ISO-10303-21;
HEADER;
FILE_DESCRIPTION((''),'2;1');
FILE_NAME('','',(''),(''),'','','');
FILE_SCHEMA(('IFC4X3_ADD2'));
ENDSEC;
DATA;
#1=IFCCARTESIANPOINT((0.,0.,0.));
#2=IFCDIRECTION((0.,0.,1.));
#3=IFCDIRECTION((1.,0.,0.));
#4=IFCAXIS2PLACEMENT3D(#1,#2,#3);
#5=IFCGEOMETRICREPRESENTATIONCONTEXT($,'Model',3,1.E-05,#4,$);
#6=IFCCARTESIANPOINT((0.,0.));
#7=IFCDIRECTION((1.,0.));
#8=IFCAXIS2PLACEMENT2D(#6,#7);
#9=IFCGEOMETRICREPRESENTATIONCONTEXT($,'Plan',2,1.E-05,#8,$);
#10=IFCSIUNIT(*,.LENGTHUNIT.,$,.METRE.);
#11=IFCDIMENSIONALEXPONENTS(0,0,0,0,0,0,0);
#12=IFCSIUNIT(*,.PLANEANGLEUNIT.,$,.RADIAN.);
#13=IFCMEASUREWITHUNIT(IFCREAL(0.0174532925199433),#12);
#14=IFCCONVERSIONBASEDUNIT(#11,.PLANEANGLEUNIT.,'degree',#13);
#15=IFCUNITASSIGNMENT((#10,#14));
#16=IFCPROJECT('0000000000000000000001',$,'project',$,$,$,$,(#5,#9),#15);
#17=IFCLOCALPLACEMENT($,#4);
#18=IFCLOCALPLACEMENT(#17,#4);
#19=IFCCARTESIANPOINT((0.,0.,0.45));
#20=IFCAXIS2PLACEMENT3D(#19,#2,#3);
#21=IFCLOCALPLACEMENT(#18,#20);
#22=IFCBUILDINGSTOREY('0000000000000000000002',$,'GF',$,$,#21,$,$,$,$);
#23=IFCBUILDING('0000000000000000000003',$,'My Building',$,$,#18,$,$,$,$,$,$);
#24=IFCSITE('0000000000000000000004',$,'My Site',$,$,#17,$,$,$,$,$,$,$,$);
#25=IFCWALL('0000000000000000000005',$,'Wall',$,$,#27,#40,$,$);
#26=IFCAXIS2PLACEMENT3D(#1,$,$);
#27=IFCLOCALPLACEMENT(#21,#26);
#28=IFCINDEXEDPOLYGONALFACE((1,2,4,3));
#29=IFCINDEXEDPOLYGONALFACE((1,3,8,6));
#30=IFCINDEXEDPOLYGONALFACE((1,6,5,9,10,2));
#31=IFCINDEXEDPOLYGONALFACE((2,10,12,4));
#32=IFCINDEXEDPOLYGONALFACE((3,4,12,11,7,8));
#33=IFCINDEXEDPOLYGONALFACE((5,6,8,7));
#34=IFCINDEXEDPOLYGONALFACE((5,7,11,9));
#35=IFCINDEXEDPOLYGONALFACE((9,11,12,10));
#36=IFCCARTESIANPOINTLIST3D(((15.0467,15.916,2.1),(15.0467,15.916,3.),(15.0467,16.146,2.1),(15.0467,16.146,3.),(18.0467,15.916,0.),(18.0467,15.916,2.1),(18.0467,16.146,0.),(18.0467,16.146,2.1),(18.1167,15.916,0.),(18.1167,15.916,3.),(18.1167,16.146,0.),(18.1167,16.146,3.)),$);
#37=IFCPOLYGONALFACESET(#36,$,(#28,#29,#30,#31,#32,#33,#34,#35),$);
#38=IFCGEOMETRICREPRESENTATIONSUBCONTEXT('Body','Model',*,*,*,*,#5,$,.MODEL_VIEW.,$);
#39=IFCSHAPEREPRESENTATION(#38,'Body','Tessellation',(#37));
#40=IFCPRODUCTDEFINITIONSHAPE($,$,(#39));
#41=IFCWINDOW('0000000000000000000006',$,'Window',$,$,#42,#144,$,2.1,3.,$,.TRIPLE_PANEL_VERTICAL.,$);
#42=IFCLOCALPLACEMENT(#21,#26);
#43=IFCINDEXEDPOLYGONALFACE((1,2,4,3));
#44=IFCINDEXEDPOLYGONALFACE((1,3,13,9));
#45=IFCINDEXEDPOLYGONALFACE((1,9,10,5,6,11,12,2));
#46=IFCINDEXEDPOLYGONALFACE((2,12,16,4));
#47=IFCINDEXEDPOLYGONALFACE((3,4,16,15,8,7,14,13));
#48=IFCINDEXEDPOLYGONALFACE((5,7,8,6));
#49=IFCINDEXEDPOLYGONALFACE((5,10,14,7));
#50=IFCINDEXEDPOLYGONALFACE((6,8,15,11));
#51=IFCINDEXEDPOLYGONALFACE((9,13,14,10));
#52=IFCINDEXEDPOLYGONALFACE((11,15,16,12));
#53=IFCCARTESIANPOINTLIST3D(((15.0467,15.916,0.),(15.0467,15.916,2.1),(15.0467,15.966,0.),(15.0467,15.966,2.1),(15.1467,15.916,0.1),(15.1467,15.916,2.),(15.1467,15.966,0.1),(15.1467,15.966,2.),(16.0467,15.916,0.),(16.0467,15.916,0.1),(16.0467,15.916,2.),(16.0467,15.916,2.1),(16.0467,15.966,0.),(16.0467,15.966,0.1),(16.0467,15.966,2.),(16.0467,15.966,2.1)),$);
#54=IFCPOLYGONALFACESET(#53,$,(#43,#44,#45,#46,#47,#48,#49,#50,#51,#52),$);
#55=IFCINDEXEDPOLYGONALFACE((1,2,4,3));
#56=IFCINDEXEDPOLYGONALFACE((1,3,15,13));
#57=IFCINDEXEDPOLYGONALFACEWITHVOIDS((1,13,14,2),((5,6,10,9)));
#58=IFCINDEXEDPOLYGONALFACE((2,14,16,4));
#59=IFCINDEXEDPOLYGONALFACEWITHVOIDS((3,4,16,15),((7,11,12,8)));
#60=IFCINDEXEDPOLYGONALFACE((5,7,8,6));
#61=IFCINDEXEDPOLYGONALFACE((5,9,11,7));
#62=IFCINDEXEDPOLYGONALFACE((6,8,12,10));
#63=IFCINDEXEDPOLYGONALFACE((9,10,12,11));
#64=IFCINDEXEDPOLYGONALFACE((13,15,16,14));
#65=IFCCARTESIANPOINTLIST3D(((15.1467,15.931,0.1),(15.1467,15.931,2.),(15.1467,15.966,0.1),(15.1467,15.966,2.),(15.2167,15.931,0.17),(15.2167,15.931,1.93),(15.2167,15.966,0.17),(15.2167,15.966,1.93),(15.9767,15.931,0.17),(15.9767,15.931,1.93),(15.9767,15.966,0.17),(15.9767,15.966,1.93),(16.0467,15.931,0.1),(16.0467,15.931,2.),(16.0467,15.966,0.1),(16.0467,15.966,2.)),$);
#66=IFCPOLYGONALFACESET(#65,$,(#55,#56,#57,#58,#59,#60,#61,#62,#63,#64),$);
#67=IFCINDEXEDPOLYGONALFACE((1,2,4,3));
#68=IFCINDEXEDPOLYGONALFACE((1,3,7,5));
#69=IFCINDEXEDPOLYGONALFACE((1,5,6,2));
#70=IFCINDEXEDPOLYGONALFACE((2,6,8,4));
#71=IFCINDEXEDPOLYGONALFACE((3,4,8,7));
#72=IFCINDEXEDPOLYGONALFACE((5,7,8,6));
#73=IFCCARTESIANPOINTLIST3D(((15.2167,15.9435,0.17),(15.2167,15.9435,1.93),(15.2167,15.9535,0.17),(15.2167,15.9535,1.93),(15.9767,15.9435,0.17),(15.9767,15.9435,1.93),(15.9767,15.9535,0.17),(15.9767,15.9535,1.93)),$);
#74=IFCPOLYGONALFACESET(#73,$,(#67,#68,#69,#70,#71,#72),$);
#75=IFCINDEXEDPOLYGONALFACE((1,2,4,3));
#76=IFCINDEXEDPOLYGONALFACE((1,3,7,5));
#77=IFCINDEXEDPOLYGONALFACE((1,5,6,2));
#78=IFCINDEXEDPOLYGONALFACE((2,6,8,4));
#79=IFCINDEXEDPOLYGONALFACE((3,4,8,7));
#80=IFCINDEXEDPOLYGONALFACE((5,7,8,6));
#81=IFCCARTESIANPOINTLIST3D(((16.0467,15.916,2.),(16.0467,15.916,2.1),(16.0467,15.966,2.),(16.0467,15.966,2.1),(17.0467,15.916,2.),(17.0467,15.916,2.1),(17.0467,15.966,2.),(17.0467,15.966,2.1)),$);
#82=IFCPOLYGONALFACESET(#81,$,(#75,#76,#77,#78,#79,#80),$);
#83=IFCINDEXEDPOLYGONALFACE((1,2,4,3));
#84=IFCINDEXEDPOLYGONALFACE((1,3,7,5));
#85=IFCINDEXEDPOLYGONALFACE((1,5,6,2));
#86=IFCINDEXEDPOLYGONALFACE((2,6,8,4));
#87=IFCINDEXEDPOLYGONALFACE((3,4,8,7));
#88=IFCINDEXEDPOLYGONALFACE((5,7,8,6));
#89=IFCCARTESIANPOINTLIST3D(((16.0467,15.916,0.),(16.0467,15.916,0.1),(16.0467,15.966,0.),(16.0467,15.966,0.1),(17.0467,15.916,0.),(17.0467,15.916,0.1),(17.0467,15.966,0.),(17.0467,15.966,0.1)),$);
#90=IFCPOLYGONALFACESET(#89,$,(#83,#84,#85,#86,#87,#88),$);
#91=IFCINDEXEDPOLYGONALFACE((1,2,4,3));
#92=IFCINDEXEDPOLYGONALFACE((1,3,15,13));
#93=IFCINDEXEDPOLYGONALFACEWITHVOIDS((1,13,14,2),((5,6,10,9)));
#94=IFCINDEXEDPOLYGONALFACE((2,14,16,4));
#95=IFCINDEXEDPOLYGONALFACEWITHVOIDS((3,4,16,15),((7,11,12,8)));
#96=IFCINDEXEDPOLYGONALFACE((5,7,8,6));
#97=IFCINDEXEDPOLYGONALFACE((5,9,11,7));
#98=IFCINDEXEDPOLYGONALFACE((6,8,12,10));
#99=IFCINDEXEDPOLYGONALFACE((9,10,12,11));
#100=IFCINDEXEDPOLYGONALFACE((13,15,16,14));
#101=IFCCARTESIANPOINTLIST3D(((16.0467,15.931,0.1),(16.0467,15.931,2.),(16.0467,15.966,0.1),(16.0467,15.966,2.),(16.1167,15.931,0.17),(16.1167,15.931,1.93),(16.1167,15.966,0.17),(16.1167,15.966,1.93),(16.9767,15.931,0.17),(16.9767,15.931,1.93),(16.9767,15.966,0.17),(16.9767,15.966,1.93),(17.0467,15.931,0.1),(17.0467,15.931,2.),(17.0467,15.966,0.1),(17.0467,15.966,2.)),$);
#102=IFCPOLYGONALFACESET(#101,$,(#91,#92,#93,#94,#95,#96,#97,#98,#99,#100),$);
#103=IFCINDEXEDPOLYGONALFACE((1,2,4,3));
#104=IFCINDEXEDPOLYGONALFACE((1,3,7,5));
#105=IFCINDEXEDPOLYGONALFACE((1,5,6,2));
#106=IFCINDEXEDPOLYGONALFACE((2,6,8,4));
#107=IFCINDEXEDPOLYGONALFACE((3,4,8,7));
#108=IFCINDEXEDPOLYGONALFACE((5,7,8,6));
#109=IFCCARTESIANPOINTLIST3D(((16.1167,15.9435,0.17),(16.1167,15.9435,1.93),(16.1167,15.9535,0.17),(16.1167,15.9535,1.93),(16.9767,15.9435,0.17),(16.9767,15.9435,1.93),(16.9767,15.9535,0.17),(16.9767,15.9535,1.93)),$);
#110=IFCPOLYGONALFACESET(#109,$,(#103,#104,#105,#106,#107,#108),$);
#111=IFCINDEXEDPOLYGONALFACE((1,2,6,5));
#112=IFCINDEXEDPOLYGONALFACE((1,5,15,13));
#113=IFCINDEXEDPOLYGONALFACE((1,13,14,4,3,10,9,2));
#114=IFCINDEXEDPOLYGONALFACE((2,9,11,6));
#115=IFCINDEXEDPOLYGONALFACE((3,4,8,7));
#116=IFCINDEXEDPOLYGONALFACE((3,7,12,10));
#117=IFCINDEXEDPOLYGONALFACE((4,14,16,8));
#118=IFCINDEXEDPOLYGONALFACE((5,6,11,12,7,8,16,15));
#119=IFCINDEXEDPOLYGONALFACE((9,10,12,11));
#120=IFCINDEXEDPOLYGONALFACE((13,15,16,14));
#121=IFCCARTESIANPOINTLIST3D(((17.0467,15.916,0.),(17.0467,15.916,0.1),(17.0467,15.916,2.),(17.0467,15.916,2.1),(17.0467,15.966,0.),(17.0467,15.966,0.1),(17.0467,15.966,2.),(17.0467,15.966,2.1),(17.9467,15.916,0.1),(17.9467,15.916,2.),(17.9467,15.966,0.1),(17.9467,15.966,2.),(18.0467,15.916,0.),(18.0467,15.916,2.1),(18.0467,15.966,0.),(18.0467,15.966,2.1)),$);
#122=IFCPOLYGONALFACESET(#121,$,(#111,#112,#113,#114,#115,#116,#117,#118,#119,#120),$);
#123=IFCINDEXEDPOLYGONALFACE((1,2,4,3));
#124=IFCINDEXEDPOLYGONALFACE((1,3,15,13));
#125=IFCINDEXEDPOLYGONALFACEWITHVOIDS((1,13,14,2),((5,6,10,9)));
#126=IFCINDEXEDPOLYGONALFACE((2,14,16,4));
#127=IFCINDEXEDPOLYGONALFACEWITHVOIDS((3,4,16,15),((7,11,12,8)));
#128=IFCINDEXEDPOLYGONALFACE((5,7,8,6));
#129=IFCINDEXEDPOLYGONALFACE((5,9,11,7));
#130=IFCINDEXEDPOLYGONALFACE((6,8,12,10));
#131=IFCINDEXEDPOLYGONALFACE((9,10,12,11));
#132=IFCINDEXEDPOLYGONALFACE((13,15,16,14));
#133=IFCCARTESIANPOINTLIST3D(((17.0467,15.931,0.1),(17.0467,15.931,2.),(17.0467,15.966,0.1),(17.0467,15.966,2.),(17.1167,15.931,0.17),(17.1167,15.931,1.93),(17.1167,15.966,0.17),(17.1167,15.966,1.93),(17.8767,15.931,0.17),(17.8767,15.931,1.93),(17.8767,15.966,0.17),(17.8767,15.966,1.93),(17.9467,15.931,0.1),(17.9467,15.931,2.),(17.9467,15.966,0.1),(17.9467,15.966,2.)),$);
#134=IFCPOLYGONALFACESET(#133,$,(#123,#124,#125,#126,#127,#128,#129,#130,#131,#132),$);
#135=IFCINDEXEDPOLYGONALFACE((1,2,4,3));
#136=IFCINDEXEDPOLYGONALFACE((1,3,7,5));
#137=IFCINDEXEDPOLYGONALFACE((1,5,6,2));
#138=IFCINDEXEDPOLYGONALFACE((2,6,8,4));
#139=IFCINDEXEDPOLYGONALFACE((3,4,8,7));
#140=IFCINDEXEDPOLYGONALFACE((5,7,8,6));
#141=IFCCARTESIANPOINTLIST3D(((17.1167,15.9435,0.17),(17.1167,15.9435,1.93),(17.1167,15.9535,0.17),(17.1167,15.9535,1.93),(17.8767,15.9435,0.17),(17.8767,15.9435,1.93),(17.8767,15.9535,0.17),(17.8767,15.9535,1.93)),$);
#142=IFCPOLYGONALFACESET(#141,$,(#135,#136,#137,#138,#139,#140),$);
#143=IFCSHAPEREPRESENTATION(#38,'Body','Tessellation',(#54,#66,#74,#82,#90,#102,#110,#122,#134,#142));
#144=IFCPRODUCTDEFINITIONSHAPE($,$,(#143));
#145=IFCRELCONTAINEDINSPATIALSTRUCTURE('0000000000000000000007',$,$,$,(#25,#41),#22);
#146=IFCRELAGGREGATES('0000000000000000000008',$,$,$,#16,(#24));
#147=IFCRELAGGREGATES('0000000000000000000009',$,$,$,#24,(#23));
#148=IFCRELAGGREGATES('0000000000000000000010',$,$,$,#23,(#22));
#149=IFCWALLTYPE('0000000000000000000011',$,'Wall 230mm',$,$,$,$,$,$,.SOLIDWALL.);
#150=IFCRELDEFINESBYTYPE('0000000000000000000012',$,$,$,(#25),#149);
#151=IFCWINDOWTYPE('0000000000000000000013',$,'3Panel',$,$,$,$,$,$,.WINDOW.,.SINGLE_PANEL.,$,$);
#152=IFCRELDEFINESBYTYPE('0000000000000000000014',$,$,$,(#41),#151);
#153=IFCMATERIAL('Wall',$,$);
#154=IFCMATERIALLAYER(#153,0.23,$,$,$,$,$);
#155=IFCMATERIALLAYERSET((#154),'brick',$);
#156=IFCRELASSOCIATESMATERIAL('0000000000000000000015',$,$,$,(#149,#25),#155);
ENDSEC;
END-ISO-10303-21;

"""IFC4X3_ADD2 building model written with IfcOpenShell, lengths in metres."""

from ifc_helpers import new_model, entity, si_unit, converted_unit, frame, origin_with_axes, origin_2d_with_axis, place, context, subcontext, project, spatial, line, indexed_curve, outline, extrude, shape, source, transform, mapped, material, layer, layer_set, layer_usage, type_object, type_shapes, element, fill, save


model = new_model("IFC4X3_ADD2")

# Units and contexts
model_context = context("Model", 3, precision=1e-05, world=origin_with_axes())
plan_context = context("Plan", 2, precision=1e-05, world=origin_2d_with_axis())
body_context_1 = subcontext(model_context, "Body", "Model", "MODEL_VIEW")
body_context_2 = subcontext(plan_context, "Body", "Plan", "PLAN_VIEW")
ifc_project = project(units=[si_unit("LENGTHUNIT", "METRE"), converted_unit("PLANEANGLEUNIT", "degree", entity("IfcReal", 0.0174532925199433), si_unit("PLANEANGLEUNIT", "RADIAN"), dimensions=[0, 0, 0, 0, 0, 0, 0])], contexts=[model_context, plan_context])

# Site, building, storey
site_placement = place(None, origin_with_axes())
site = spatial("IfcSite", under=ifc_project, at=site_placement, Name="My Site")
building_placement = place(site_placement, origin_with_axes())
building = spatial("IfcBuilding", under=site, at=building_placement, Name="My Building")
storey_placement = place(building_placement, frame((0.0, 0.0, 0.45), z_axis=(0.0, 0.0, 1.0), x_axis=(1.0, 0.0, 0.0)))
storey = spatial("IfcBuildingStorey", under=building, at=storey_placement, Name="GF")

# Wall, opening, window
ifc_material_1 = material(Name="Wall")
ifc_layer = layer(ifc_material_1, 0.23)
ifc_layer_set = layer_set([ifc_layer], Name="brick")
ifc_layer_usage_1 = layer_usage(ifc_layer_set, "AXIS2", "POSITIVE", 0.0)
wall_type = type_object("IfcWallType", Name="Wall 230mm", PredefinedType="SOLIDWALL", material=ifc_layer_set)
wall_1_placement = place(storey_placement, frame((15.0467, 15.916, 0.0), z_axis=(0.0, 0.0, 1.0), x_axis=(1.0, 0.0, 0.0)))
wall_1 = element("IfcWall", 1, at=wall_1_placement, inside=storey, type_object=wall_type, material=ifc_layer_usage_1, Name="Wall", context=body_context_1, shape_type="SweptSolid", body=[
    extrude(outline(indexed_curve([(0.0, 0.0), (0.0, 0.23), (3.07, 0.23), (3.07, 0.0), (0.0, 0.0)], self_intersect=False)), origin_with_axes(), (0.0, 0.0, 1.0), 3.0),
])
shared_shape_1 = source(origin_with_axes(), body_context_1, "Body", "SweptSolid", [
    extrude(outline(indexed_curve([(0.0, 0.0), (3.0, 0.0), (3.0, 2.1), (0.0, 2.1)], segments=[line(1, 2, 3, 4, 1)])), frame((0.0, -0.6, 0.0), z_axis=(0.0, -1.0, 0.0), x_axis=(1.0, 0.0, 0.0)), (0.0, 0.0, -1.0), 1.2),
])
opening_1_placement = place(wall_1_placement, frame((0.0, 0.0, 0.0), z_axis=(0.0, 0.0, 1.0), x_axis=(1.0, 0.0, 0.0)))
opening_1 = element("IfcOpeningElement", 2, at=opening_1_placement, cuts=wall_1, PredefinedType="OPENING", context=body_context_1, shape_type="MappedRepresentation", body=[
    mapped(shared_shape_1, transform((0.0, 0.0, 0.0), x_axis=(1.0, 0.0, 0.0), y_axis=(0.0, 1.0, 0.0), z_axis=(0.0, 0.0, 1.0), scale=1.0)),
])
window_type_1 = type_object("IfcWindowType", Name="3Panel", PartitioningType="SINGLE_PANEL", PredefinedType="WINDOW")
shared_shape_2 = source(origin_with_axes(), body_context_1, "Body", "SweptSolid", [
    extrude(outline(indexed_curve([(1.0, 0.0), (0.0, 0.0), (0.0, 2.1), (1.0, 2.1), (1.0, 2.0), (0.1, 2.0), (0.1, 0.1), (1.0, 0.1)], segments=[line(1, 2, 3, 4, 5, 6, 7, 8, 1)])), frame((0.0, 0.0, 0.0), z_axis=(0.0, -1.0, 0.0), x_axis=(1.0, 0.0, 0.0)), (0.0, 0.0, -1.0), 0.05),
    extrude(outline(indexed_curve([(0.0, 0.0), (0.9, 0.0), (0.9, 1.9), (0.0, 1.9)], segments=[line(1, 2, 3, 4, 1)]), holes=[indexed_curve([(0.07, 0.07), (0.83, 0.07), (0.83, 1.83), (0.07, 1.83)], segments=[line(1, 2, 3, 4, 1)])]), frame((0.1, 0.015, 0.1), z_axis=(0.0, -1.0, 0.0), x_axis=(1.0, 0.0, 0.0)), (0.0, 0.0, -1.0), 0.035),
    extrude(outline(indexed_curve([(0.07, 0.07), (0.83, 0.07), (0.83, 1.83), (0.07, 1.83)], segments=[line(1, 2, 3, 4, 1)])), frame((0.1, 0.0275, 0.1), z_axis=(0.0, -1.0, 0.0), x_axis=(1.0, 0.0, 0.0)), (0.0, 0.0, -1.0), 0.01),
    extrude(outline(indexed_curve([(0.0, 2.1), (1.0, 2.1), (1.0, 2.0), (0.0, 2.0)], segments=[line(1, 2, 3, 4, 1)])), frame((1.0, 0.0, 0.0), z_axis=(0.0, -1.0, 0.0), x_axis=(1.0, 0.0, 0.0)), (0.0, 0.0, -1.0), 0.05),
    extrude(outline(indexed_curve([(1.0, 0.0), (0.0, 0.0), (0.0, 0.1), (1.0, 0.1)], segments=[line(1, 2, 3, 4, 1)])), frame((1.0, 0.0, 0.0), z_axis=(0.0, -1.0, 0.0), x_axis=(1.0, 0.0, 0.0)), (0.0, 0.0, -1.0), 0.05),
    extrude(outline(indexed_curve([(0.0, 0.0), (1.0, 0.0), (1.0, 1.9), (0.0, 1.9)], segments=[line(1, 2, 3, 4, 1)]), holes=[indexed_curve([(0.07, 0.07), (0.93, 0.07), (0.93, 1.83), (0.07, 1.83)], segments=[line(1, 2, 3, 4, 1)])]), frame((1.0, 0.015, 0.1), z_axis=(0.0, -1.0, 0.0), x_axis=(1.0, 0.0, 0.0)), (0.0, 0.0, -1.0), 0.035),
    extrude(outline(indexed_curve([(0.07, 0.07), (0.93, 0.07), (0.93, 1.83), (0.07, 1.83)], segments=[line(1, 2, 3, 4, 1)])), frame((1.0, 0.0275, 0.1), z_axis=(0.0, -1.0, 0.0), x_axis=(1.0, 0.0, 0.0)), (0.0, 0.0, -1.0), 0.01),
    extrude(outline(indexed_curve([(0.0, 2.1), (1.0, 2.1), (1.0, 0.0), (0.0, 0.0), (0.0, 0.1), (0.9, 0.1), (0.9, 2.0), (0.0, 2.0)], segments=[line(1, 2, 3, 4, 5, 6, 7, 8, 1)])), frame((2.0, 0.0, 0.0), z_axis=(0.0, -1.0, 0.0), x_axis=(1.0, 0.0, 0.0)), (0.0, 0.0, -1.0), 0.05),
    extrude(outline(indexed_curve([(0.0, 0.0), (0.9, 0.0), (0.9, 1.9), (0.0, 1.9)], segments=[line(1, 2, 3, 4, 1)]), holes=[indexed_curve([(0.07, 0.07), (0.83, 0.07), (0.83, 1.83), (0.07, 1.83)], segments=[line(1, 2, 3, 4, 1)])]), frame((2.0, 0.015, 0.1), z_axis=(0.0, -1.0, 0.0), x_axis=(1.0, 0.0, 0.0)), (0.0, 0.0, -1.0), 0.035),
    extrude(outline(indexed_curve([(0.07, 0.07), (0.83, 0.07), (0.83, 1.83), (0.07, 1.83)], segments=[line(1, 2, 3, 4, 1)])), frame((2.0, 0.0275, 0.1), z_axis=(0.0, -1.0, 0.0), x_axis=(1.0, 0.0, 0.0)), (0.0, 0.0, -1.0), 0.01),
])
shared_shape_3 = source(origin_with_axes(), body_context_2, "Body", "Curve2D", [
    entity("IfcIndexedPolyCurve", entity("IfcCartesianPointList2D", [[0.1, 0.0], [1.0, 0.0]])),
    entity("IfcIndexedPolyCurve", entity("IfcCartesianPointList2D", [[0.0, 0.05], [0.1, 0.05], [0.1, 0.0], [0.0, 0.0]]), [entity("IfcLineIndex", [1, 2, 3, 4, 1])]),
    entity("IfcIndexedPolyCurve", entity("IfcCartesianPointList2D", [[1.0, 0.05], [1.0, 0.05], [1.0, 0.0], [1.0, 0.0]])),
    entity("IfcIndexedPolyCurve", entity("IfcCartesianPointList2D", [[0.1, 0.015], [0.17, 0.015], [0.17, 0.05], [0.1, 0.05]]), [entity("IfcLineIndex", [1, 2, 3, 4, 1])]),
    entity("IfcIndexedPolyCurve", entity("IfcCartesianPointList2D", [[1.0, 0.015], [0.93, 0.015], [0.93, 0.05], [1.0, 0.05]]), [entity("IfcLineIndex", [1, 2, 3, 4, 1])]),
    entity("IfcIndexedPolyCurve", entity("IfcCartesianPointList2D", [[0.17, 0.015], [0.93, 0.015]])),
    entity("IfcIndexedPolyCurve", entity("IfcCartesianPointList2D", [[0.17, 0.05], [0.93, 0.05]])),
    entity("IfcIndexedPolyCurve", entity("IfcCartesianPointList2D", [[0.17, 0.0325], [0.93, 0.0325]])),
    entity("IfcIndexedPolyCurve", entity("IfcCartesianPointList2D", [[1.0, 0.0], [2.0, 0.0]])),
    entity("IfcIndexedPolyCurve", entity("IfcCartesianPointList2D", [[1.0, 0.05], [1.0, 0.05], [1.0, 0.0], [1.0, 0.0]])),
    entity("IfcIndexedPolyCurve", entity("IfcCartesianPointList2D", [[2.0, 0.05], [2.0, 0.05], [2.0, 0.0], [2.0, 0.0]])),
    entity("IfcIndexedPolyCurve", entity("IfcCartesianPointList2D", [[1.0, 0.015], [1.07, 0.015], [1.07, 0.05], [1.0, 0.05]]), [entity("IfcLineIndex", [1, 2, 3, 4, 1])]),
    entity("IfcIndexedPolyCurve", entity("IfcCartesianPointList2D", [[2.0, 0.015], [1.93, 0.015], [1.93, 0.05], [2.0, 0.05]]), [entity("IfcLineIndex", [1, 2, 3, 4, 1])]),
    entity("IfcIndexedPolyCurve", entity("IfcCartesianPointList2D", [[1.07, 0.015], [1.93, 0.015]])),
    entity("IfcIndexedPolyCurve", entity("IfcCartesianPointList2D", [[1.07, 0.05], [1.93, 0.05]])),
    entity("IfcIndexedPolyCurve", entity("IfcCartesianPointList2D", [[1.07, 0.0325], [1.93, 0.0325]])),
    entity("IfcIndexedPolyCurve", entity("IfcCartesianPointList2D", [[2.0, 0.0], [2.9, 0.0]])),
    entity("IfcIndexedPolyCurve", entity("IfcCartesianPointList2D", [[2.0, 0.05], [2.0, 0.05], [2.0, 0.0], [2.0, 0.0]])),
    entity("IfcIndexedPolyCurve", entity("IfcCartesianPointList2D", [[3.0, 0.05], [2.9, 0.05], [2.9, 0.0], [3.0, 0.0]]), [entity("IfcLineIndex", [1, 2, 3, 4, 1])]),
    entity("IfcIndexedPolyCurve", entity("IfcCartesianPointList2D", [[2.0, 0.015], [2.07, 0.015], [2.07, 0.05], [2.0, 0.05]]), [entity("IfcLineIndex", [1, 2, 3, 4, 1])]),
    entity("IfcIndexedPolyCurve", entity("IfcCartesianPointList2D", [[2.9, 0.015], [2.83, 0.015], [2.83, 0.05], [2.9, 0.05]]), [entity("IfcLineIndex", [1, 2, 3, 4, 1])]),
    entity("IfcIndexedPolyCurve", entity("IfcCartesianPointList2D", [[2.07, 0.015], [2.83, 0.015]])),
    entity("IfcIndexedPolyCurve", entity("IfcCartesianPointList2D", [[2.07, 0.05], [2.83, 0.05]])),
    entity("IfcIndexedPolyCurve", entity("IfcCartesianPointList2D", [[2.07, 0.0325], [2.83, 0.0325]])),
])
type_shapes(window_type_1, [shared_shape_2, shared_shape_3])
window_1_placement = place(opening_1_placement, origin_with_axes())
window_1 = element("IfcWindow", 3, at=window_1_placement, inside=storey, type_object=window_type_1, Name="Window", OverallHeight=2.1, OverallWidth=3.0, PartitioningType="TRIPLE_PANEL_VERTICAL", shapes=[
    shape(body_context_1, "Body", "MappedRepresentation", [mapped(shared_shape_2, transform((0.0, 0.0, 0.0), x_axis=(1.0, 0.0, 0.0), y_axis=(0.0, 1.0, 0.0), z_axis=(0.0, 0.0, 1.0), scale=1.0))]),
    shape(body_context_2, "Body", "MappedRepresentation", [mapped(shared_shape_3, transform((0.0, 0.0, 0.0), x_axis=(1.0, 0.0, 0.0), y_axis=(0.0, 1.0, 0.0), z_axis=(0.0, 0.0, 1.0), scale=1.0))]),
])
fill(opening_1, window_1)

save(model, "model.ifc")
